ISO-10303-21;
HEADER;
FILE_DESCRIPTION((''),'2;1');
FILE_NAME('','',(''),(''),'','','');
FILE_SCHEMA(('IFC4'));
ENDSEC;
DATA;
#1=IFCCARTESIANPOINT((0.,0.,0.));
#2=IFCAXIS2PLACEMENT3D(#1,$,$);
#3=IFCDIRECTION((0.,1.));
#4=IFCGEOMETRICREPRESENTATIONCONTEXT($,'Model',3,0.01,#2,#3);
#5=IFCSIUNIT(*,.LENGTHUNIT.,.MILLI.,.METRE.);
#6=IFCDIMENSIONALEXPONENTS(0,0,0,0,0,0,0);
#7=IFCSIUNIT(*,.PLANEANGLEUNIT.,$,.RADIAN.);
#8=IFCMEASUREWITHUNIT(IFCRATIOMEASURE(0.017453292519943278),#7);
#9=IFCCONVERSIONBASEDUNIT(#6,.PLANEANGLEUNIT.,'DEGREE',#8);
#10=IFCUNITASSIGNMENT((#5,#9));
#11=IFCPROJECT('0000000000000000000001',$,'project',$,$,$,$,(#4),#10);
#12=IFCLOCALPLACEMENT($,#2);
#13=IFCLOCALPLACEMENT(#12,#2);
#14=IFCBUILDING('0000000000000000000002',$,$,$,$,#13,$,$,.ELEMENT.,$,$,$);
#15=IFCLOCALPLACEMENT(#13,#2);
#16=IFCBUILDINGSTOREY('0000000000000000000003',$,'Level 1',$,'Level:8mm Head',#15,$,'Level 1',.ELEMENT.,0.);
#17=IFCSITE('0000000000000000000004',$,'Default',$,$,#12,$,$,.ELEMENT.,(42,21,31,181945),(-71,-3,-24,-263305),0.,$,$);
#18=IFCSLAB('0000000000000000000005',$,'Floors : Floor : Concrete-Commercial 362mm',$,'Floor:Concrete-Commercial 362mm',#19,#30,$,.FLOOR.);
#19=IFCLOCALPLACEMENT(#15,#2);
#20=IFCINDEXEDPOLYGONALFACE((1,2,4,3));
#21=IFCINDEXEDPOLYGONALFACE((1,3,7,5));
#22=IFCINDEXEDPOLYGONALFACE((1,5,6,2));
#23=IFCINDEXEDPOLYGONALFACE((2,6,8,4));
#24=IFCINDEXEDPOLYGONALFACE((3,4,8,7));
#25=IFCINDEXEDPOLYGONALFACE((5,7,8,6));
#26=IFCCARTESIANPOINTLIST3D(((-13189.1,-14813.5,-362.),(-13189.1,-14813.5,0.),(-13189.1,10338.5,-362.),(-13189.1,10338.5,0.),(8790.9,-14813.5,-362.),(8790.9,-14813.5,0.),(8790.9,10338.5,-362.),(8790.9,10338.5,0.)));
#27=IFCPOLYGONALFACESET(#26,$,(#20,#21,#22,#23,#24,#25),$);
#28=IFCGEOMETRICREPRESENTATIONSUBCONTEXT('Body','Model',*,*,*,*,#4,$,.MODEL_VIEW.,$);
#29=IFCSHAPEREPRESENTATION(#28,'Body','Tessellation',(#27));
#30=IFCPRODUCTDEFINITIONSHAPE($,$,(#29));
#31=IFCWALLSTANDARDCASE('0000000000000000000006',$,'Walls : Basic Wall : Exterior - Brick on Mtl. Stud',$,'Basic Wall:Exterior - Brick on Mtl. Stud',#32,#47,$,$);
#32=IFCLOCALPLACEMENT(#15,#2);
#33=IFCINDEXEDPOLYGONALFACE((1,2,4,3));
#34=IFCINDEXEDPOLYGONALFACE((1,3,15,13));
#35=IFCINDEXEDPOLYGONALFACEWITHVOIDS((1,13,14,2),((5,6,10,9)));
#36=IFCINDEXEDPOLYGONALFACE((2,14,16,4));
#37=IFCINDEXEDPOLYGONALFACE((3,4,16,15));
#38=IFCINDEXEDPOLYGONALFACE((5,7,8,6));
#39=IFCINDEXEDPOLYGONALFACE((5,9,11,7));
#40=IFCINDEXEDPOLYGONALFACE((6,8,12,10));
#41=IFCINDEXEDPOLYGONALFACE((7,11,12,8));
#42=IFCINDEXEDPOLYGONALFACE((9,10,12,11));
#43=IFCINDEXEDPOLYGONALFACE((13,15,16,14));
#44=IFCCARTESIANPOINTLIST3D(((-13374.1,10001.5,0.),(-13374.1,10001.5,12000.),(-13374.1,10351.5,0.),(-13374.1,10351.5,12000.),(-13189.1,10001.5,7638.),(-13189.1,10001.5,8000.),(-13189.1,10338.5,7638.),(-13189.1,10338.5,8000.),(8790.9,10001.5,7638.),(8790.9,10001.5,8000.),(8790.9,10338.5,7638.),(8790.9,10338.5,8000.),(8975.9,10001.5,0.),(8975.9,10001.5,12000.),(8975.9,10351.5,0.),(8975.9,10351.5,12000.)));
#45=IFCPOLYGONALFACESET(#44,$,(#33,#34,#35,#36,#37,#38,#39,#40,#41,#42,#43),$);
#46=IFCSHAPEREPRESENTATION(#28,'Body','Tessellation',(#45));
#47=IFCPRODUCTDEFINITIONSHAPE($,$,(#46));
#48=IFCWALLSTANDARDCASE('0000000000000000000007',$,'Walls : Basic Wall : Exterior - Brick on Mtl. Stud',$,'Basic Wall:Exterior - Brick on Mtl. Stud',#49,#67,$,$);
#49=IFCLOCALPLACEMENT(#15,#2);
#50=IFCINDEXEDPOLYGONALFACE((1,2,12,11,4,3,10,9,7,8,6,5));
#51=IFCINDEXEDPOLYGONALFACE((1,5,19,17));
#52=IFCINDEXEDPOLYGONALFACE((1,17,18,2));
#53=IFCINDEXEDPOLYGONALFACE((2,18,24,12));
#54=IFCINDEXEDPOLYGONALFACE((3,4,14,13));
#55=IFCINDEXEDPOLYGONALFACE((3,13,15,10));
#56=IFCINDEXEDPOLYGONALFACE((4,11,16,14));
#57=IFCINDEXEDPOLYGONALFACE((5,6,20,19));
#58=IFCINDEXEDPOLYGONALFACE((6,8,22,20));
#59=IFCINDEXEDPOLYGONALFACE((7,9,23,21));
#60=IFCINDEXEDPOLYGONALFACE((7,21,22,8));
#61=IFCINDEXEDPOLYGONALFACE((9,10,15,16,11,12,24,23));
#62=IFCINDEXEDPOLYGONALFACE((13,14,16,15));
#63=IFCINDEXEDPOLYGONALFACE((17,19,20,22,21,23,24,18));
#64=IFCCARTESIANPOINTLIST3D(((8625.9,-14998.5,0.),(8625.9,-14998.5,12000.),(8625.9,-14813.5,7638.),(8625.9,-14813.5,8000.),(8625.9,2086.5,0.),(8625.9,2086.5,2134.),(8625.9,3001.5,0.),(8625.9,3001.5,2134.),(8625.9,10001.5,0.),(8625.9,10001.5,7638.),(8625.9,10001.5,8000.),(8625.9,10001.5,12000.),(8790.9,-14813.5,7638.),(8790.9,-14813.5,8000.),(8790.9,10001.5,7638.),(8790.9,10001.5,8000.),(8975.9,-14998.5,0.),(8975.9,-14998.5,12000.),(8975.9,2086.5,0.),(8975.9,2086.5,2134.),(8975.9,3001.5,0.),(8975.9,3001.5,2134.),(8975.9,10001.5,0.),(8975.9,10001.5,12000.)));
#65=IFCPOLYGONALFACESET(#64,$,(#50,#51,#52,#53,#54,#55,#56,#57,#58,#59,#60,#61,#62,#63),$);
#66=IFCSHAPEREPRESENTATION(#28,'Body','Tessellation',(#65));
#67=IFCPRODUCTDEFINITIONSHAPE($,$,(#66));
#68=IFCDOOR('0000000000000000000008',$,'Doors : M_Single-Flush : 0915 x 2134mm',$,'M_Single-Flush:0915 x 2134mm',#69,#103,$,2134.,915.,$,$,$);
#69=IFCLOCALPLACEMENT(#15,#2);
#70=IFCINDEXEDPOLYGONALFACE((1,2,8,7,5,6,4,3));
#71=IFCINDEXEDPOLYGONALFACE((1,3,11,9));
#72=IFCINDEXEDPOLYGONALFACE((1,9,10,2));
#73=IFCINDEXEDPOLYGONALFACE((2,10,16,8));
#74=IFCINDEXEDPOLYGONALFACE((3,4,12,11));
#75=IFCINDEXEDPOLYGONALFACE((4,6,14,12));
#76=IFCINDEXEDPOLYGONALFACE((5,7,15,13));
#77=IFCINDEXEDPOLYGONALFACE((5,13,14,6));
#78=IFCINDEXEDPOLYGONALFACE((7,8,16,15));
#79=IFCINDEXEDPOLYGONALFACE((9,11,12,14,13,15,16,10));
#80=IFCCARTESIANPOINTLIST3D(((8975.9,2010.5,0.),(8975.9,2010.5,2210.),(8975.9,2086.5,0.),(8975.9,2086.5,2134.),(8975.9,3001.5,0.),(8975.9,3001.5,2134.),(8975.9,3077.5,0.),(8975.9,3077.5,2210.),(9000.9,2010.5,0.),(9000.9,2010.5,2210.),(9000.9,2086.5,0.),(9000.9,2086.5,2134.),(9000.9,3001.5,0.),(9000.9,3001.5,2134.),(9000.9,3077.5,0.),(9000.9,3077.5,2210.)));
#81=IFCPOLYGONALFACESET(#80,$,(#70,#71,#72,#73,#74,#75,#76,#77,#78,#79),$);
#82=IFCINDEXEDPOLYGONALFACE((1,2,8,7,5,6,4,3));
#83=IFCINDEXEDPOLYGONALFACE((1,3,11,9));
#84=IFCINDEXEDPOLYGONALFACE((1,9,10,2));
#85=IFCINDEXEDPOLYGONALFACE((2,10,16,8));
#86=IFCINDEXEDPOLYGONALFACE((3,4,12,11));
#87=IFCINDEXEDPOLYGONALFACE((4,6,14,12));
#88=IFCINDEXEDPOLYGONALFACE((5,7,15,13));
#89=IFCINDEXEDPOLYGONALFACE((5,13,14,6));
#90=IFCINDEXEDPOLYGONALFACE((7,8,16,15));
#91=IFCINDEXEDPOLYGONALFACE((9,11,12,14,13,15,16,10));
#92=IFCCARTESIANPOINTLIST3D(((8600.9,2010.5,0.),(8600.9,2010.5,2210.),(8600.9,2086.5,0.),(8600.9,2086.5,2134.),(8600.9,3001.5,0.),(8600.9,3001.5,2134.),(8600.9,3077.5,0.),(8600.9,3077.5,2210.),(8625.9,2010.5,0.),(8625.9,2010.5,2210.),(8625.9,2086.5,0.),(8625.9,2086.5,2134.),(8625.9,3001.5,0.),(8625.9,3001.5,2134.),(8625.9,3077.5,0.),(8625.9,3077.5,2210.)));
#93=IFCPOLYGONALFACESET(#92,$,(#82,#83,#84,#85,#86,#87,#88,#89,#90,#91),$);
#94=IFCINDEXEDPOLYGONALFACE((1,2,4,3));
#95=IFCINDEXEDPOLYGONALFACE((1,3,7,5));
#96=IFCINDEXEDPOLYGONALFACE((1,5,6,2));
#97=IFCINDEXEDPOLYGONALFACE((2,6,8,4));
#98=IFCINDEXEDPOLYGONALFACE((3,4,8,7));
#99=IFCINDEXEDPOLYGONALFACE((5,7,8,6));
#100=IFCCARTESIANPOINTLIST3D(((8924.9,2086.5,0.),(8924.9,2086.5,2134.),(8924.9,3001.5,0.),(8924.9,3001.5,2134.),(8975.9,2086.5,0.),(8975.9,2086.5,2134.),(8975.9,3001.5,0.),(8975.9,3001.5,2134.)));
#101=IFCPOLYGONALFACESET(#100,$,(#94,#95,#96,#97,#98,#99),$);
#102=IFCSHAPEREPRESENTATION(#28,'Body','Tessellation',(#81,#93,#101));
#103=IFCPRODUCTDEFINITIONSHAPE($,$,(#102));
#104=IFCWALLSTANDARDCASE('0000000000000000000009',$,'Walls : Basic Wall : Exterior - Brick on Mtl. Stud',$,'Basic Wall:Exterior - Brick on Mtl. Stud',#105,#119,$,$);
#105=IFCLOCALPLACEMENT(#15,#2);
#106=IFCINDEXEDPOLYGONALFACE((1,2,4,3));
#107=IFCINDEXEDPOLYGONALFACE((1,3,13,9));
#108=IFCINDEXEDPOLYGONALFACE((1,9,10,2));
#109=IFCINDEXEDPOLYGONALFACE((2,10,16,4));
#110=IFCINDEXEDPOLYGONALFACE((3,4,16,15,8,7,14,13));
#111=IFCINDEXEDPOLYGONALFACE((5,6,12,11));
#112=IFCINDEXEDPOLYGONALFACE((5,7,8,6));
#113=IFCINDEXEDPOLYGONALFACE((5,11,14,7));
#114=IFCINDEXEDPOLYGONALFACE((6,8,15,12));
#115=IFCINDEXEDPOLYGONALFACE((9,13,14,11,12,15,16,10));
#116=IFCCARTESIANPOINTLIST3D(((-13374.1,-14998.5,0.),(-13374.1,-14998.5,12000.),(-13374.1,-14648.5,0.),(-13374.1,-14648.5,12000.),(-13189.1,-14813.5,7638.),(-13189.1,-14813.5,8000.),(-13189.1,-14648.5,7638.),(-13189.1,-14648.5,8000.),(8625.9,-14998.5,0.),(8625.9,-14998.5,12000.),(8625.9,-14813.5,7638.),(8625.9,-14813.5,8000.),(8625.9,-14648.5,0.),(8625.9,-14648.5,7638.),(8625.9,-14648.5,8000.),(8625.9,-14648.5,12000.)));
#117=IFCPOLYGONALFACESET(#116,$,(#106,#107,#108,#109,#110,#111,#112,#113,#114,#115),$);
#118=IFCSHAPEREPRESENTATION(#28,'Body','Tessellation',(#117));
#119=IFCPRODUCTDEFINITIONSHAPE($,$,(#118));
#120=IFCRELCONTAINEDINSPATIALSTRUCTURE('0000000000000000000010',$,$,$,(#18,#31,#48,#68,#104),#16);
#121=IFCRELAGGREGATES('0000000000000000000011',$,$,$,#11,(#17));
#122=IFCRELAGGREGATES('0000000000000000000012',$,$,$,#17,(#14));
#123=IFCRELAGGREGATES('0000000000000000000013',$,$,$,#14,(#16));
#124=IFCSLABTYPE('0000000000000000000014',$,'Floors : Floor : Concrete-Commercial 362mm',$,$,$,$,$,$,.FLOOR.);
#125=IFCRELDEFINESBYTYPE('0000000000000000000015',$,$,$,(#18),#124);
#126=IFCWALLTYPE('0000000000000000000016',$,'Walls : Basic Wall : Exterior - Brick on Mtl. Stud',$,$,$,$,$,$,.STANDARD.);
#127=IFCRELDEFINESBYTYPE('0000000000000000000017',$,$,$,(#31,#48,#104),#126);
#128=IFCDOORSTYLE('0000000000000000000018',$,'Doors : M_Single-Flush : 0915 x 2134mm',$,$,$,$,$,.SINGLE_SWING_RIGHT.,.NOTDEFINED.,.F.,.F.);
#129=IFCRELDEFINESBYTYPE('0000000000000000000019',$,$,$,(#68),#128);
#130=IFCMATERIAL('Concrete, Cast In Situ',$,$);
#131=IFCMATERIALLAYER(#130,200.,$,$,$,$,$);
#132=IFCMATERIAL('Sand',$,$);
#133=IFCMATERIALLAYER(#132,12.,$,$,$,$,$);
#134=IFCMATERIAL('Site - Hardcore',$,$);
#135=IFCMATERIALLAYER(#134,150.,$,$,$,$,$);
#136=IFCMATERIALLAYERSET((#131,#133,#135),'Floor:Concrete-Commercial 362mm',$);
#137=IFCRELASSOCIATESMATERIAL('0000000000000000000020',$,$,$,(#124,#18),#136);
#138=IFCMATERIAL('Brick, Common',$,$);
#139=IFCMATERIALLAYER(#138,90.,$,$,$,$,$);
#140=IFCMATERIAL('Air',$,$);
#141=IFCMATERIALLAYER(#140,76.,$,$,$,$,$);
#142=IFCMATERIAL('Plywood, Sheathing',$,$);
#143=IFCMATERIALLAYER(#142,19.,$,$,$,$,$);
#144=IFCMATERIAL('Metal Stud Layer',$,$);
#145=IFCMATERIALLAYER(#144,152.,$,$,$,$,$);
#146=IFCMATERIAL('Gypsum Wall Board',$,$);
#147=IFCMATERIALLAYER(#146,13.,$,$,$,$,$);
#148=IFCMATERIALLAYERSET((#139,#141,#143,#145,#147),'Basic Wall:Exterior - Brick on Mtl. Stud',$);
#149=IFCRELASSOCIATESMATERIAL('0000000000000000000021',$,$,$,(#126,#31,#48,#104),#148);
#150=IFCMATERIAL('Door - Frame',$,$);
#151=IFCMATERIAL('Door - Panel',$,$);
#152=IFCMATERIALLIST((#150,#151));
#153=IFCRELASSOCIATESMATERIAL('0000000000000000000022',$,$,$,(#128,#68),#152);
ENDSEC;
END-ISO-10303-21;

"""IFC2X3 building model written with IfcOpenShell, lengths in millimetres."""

from ifc_helpers import new_model, entity, si_unit, converted_unit, direction, frame, frame_2d, origin, place, context, subcontext, project, spatial, polyline, rectangle, outline, extrude, source, transform, mapped, material, material_list, layer, layer_set, layer_usage, type_object, type_shapes, element, fill, save


model = new_model("IFC2X3")

# Units and contexts
model_context = context("Model", 3, precision=0.01, world=origin(), true_north=direction((0.0, 1.0)))
body_context = subcontext(model_context, "Body", "Model", "MODEL_VIEW")
ifc_project = project(units=[si_unit("LENGTHUNIT", "METRE", prefix="MILLI"), converted_unit("PLANEANGLEUNIT", "DEGREE", entity("IfcRatioMeasure", 0.017453292519943278), si_unit("PLANEANGLEUNIT", "RADIAN"), dimensions=[0, 0, 0, 0, 0, 0, 0])], contexts=[model_context])

# Site, building, storey
site_placement = place(None, origin())
site = spatial("IfcSite", under=ifc_project, at=site_placement, Name="Default", CompositionType="ELEMENT", RefLatitude=(42, 21, 31, 181945), RefLongitude=(-71, -3, -24, -263305), RefElevation=0.0)
building_placement = place(site_placement, origin())
building = spatial("IfcBuilding", under=site, at=building_placement, CompositionType="ELEMENT")
storey_placement = place(building_placement, origin())
storey = spatial("IfcBuildingStorey", under=building, at=storey_placement, Name="Level 1", ObjectType="Level:8mm Head", LongName="Level 1", CompositionType="ELEMENT", Elevation=0.0)

# Slab
ifc_material_1 = material(Name="Concrete, Cast In Situ")
ifc_layer_1 = layer(ifc_material_1, 200.0)
ifc_material_2 = material(Name="Sand")
ifc_layer_2 = layer(ifc_material_2, 12.0)
ifc_material_3 = material(Name="Site - Hardcore")
ifc_layer_3 = layer(ifc_material_3, 150.0)
ifc_layer_set_1 = layer_set([ifc_layer_1, ifc_layer_2, ifc_layer_3], Name="Floor:Concrete-Commercial 362mm")
ifc_layer_usage_1 = layer_usage(ifc_layer_set_1, "AXIS3", "POSITIVE", 0.0)
slab_type = type_object("IfcSlabType", Name="Floors : Floor : Concrete-Commercial 362mm", PredefinedType="FLOOR", material=ifc_layer_set_1)
slab_placement = place(storey_placement, origin())
element("IfcSlab", 1, at=slab_placement, inside=storey, type_object=slab_type, material=ifc_layer_usage_1, Name="Floors : Floor : Concrete-Commercial 362mm", ObjectType="Floor:Concrete-Commercial 362mm", PredefinedType="FLOOR", context=body_context, shape_type="SweptSolid", body=[
    extrude(rectangle(XDim=25152.0, YDim=21980.0, at=frame_2d((0.0, 0.0), x_axis=(1.0, 0.0))), frame((-2199.1, -2237.5, 0.0), z_axis=(0.0, 0.0, -1.0), x_axis=(0.0, 1.0, 0.0)), (0.0, 0.0, 1.0), 362.0),
])

# Wall, opening
ifc_material_4 = material(Name="Brick, Common")
ifc_layer_4 = layer(ifc_material_4, 90.0)
ifc_material_5 = material(Name="Air")
ifc_layer_5 = layer(ifc_material_5, 76.0)
ifc_material_6 = material(Name="Plywood, Sheathing")
ifc_layer_6 = layer(ifc_material_6, 19.0)
ifc_material_7 = material(Name="Metal Stud Layer")
ifc_layer_7 = layer(ifc_material_7, 152.0)
ifc_material_8 = material(Name="Gypsum Wall Board")
ifc_layer_8 = layer(ifc_material_8, 13.0)
ifc_layer_set_2 = layer_set([ifc_layer_4, ifc_layer_5, ifc_layer_6, ifc_layer_7, ifc_layer_8], Name="Basic Wall:Exterior - Brick on Mtl. Stud")
ifc_layer_usage_2 = layer_usage(ifc_layer_set_2, "AXIS2", "POSITIVE", -175.0)
wall_type_1 = type_object("IfcWallType", Name="Walls : Basic Wall : Exterior - Brick on Mtl. Stud", PredefinedType="STANDARD", material=ifc_layer_set_2)
wall_1_placement = place(storey_placement, frame((-13374.1, 10176.5, 0.0)))
wall_1 = element("IfcWallStandardCase", 2, at=wall_1_placement, inside=storey, type_object=wall_type_1, material=ifc_layer_usage_2, Name="Walls : Basic Wall : Exterior - Brick on Mtl. Stud", ObjectType="Basic Wall:Exterior - Brick on Mtl. Stud", context=body_context, shape_type="SweptSolid", body=[
    extrude(rectangle(XDim=22350.0, YDim=350.0, at=frame_2d((11175.0, 0.0), x_axis=(-1.0, 0.0))), origin(), (0.0, 0.0, 1.0), 12000.0),
])
opening_1_placement = place(storey_placement, frame((-13374.1, 10176.5, 0.0)))
element("IfcOpeningElement", 3, at=opening_1_placement, cuts=wall_1, ObjectType="Opening", context=body_context, shape_type="SweptSolid", body=[
    extrude(rectangle(XDim=21980.0, YDim=337.0, at=frame_2d((0.0, -56.2), x_axis=(1.0, 0.0))), frame((11175.0, -62.7, 7638.0), z_axis=(0.0, 0.0, 1.0), x_axis=(-1.0, 0.0, 0.0)), (0.0, 0.0, 1.0), 362.0),
])

# Wall, openings, door
ifc_layer_usage_3 = layer_usage(ifc_layer_set_2, "AXIS2", "NEGATIVE", 175.0)
wall_2_placement = place(storey_placement, frame((8800.9, 10001.5, 0.0), z_axis=(0.0, 0.0, 1.0), x_axis=(0.0, -1.0, 0.0)))
wall_2 = element("IfcWallStandardCase", 4, at=wall_2_placement, inside=storey, type_object=wall_type_1, material=ifc_layer_usage_3, Name="Walls : Basic Wall : Exterior - Brick on Mtl. Stud", ObjectType="Basic Wall:Exterior - Brick on Mtl. Stud", context=body_context, shape_type="SweptSolid", body=[
    extrude(rectangle(XDim=25000.0, YDim=350.0, at=frame_2d((12500.0, 0.0), x_axis=(-1.0, 0.0))), origin(), (0.0, 0.0, 1.0), 12000.0),
])
opening_2_placement = place(storey_placement, frame((8800.9, 10001.5, 0.0), z_axis=(0.0, 0.0, 1.0), x_axis=(0.0, -1.0, 0.0)))
element("IfcOpeningElement", 5, at=opening_2_placement, cuts=wall_2, ObjectType="Opening", context=body_context, shape_type="SweptSolid", body=[
    extrude(rectangle(XDim=165.0, YDim=24815.0, at=frame_2d((33.5, 1727.2), x_axis=(1.0, 0.0))), frame((14134.7, -126.0, 7638.0), z_axis=(0.0, 0.0, 1.0), x_axis=(0.0, 1.0, 0.0)), (0.0, 0.0, 1.0), 362.0),
])
opening_3_placement = place(wall_2_placement, frame((7000.0, -175.0, 0.0)))
opening_3 = element("IfcOpeningElement", 6, at=opening_3_placement, cuts=wall_2, ObjectType="Opening", context=body_context, shape_type="SweptSolid", body=[
    extrude(rectangle(XDim=915.0, YDim=2134.0, at=frame_2d((1067.0, 457.5), x_axis=(0.0, 1.0))), frame((0.0, 0.0, 0.0), z_axis=(0.0, 1.0, 0.0), x_axis=(0.0, 0.0, 1.0)), (0.0, 0.0, 1.0), 350.0),
])
ifc_material_9 = material(Name="Door - Frame")
ifc_material_10 = material(Name="Door - Panel")
ifc_material_list = material_list([ifc_material_9, ifc_material_10])
door_style_1 = type_object("IfcDoorStyle", Name="Doors : M_Single-Flush : 0915 x 2134mm", ConstructionType="NOTDEFINED", OperationType="SINGLE_SWING_RIGHT", ParameterTakesPrecedence=False, Sizeable=False, material=ifc_material_list)
shared_shape_1 = source(origin(), body_context, "Body", "SweptSolid", [
    extrude(outline(polyline([(-533.5, -1124.0), (533.5, -1124.0), (533.5, 1086.0), (457.5, 1086.0), (457.5, -1048.0), (-457.5, -1048.0), (-457.5, 1086.0), (-533.5, 1086.0), (-533.5, -1124.0)])), frame((457.5, 350.0, 1086.0), z_axis=(0.0, 1.0, 0.0), x_axis=(1.0, 0.0, 0.0)), (0.0, 0.0, 1.0), 25.0),
    extrude(outline(polyline([(-1124.0, -533.5), (1086.0, -533.5), (1086.0, -457.5), (-1048.0, -457.5), (-1048.0, 457.5), (1086.0, 457.5), (1086.0, 533.5), (-1124.0, 533.5), (-1124.0, -533.5)])), frame((457.5, -25.0, 1086.0), z_axis=(0.0, 1.0, 0.0), x_axis=(0.0, 0.0, -1.0)), (0.0, 0.0, 1.0), 25.0),
    extrude(rectangle(XDim=51.0, YDim=915.0, at=frame_2d((0.0, 0.0), x_axis=(1.0, 0.0))), frame((457.5, 324.5, 0.0), z_axis=(0.0, 0.0, 1.0), x_axis=(0.0, 1.0, 0.0)), (0.0, 0.0, 1.0), 2134.0),
])
type_shapes(door_style_1, [shared_shape_1])
door_1_placement = place(opening_3_placement, origin())
door_1 = element("IfcDoor", 7, at=door_1_placement, inside=storey, type_object=door_style_1, material=ifc_material_list, Name="Doors : M_Single-Flush : 0915 x 2134mm", ObjectType="M_Single-Flush:0915 x 2134mm", OverallHeight=2134.0, OverallWidth=915.0, context=body_context, shape_type="MappedRepresentation", body=[
    mapped(shared_shape_1, transform((0.0, 0.0, 0.0), scale=1.0)),
])
fill(opening_3, door_1)

# Wall, opening
wall_3_placement = place(storey_placement, frame((8625.9, -14823.5, 0.0), z_axis=(0.0, 0.0, 1.0), x_axis=(-1.0, 0.0, 0.0)))
wall_3 = element("IfcWallStandardCase", 8, at=wall_3_placement, inside=storey, type_object=wall_type_1, material=ifc_layer_usage_3, Name="Walls : Basic Wall : Exterior - Brick on Mtl. Stud", ObjectType="Basic Wall:Exterior - Brick on Mtl. Stud", context=body_context, shape_type="SweptSolid", body=[
    extrude(rectangle(XDim=22000.0, YDim=350.0, at=frame_2d((11000.0, 0.0), x_axis=(-1.0, 0.0))), origin(), (0.0, 0.0, 1.0), 12000.0),
])
opening_4_placement = place(storey_placement, frame((8625.9, -14823.5, 0.0), z_axis=(0.0, 0.0, 1.0), x_axis=(-1.0, 0.0, 0.0)))
element("IfcOpeningElement", 9, at=opening_4_placement, cuts=wall_3, ObjectType="Opening", context=body_context, shape_type="SweptSolid", body=[
    extrude(rectangle(XDim=165.0, YDim=21815.0, at=frame_2d((44.4, 47.3), x_axis=(1.0, 0.0))), frame((10954.8, -136.9, 7638.0), z_axis=(0.0, 0.0, 1.0), x_axis=(0.0, 1.0, 0.0)), (0.0, 0.0, 1.0), 362.0),
])

save(model, "model.ifc")
